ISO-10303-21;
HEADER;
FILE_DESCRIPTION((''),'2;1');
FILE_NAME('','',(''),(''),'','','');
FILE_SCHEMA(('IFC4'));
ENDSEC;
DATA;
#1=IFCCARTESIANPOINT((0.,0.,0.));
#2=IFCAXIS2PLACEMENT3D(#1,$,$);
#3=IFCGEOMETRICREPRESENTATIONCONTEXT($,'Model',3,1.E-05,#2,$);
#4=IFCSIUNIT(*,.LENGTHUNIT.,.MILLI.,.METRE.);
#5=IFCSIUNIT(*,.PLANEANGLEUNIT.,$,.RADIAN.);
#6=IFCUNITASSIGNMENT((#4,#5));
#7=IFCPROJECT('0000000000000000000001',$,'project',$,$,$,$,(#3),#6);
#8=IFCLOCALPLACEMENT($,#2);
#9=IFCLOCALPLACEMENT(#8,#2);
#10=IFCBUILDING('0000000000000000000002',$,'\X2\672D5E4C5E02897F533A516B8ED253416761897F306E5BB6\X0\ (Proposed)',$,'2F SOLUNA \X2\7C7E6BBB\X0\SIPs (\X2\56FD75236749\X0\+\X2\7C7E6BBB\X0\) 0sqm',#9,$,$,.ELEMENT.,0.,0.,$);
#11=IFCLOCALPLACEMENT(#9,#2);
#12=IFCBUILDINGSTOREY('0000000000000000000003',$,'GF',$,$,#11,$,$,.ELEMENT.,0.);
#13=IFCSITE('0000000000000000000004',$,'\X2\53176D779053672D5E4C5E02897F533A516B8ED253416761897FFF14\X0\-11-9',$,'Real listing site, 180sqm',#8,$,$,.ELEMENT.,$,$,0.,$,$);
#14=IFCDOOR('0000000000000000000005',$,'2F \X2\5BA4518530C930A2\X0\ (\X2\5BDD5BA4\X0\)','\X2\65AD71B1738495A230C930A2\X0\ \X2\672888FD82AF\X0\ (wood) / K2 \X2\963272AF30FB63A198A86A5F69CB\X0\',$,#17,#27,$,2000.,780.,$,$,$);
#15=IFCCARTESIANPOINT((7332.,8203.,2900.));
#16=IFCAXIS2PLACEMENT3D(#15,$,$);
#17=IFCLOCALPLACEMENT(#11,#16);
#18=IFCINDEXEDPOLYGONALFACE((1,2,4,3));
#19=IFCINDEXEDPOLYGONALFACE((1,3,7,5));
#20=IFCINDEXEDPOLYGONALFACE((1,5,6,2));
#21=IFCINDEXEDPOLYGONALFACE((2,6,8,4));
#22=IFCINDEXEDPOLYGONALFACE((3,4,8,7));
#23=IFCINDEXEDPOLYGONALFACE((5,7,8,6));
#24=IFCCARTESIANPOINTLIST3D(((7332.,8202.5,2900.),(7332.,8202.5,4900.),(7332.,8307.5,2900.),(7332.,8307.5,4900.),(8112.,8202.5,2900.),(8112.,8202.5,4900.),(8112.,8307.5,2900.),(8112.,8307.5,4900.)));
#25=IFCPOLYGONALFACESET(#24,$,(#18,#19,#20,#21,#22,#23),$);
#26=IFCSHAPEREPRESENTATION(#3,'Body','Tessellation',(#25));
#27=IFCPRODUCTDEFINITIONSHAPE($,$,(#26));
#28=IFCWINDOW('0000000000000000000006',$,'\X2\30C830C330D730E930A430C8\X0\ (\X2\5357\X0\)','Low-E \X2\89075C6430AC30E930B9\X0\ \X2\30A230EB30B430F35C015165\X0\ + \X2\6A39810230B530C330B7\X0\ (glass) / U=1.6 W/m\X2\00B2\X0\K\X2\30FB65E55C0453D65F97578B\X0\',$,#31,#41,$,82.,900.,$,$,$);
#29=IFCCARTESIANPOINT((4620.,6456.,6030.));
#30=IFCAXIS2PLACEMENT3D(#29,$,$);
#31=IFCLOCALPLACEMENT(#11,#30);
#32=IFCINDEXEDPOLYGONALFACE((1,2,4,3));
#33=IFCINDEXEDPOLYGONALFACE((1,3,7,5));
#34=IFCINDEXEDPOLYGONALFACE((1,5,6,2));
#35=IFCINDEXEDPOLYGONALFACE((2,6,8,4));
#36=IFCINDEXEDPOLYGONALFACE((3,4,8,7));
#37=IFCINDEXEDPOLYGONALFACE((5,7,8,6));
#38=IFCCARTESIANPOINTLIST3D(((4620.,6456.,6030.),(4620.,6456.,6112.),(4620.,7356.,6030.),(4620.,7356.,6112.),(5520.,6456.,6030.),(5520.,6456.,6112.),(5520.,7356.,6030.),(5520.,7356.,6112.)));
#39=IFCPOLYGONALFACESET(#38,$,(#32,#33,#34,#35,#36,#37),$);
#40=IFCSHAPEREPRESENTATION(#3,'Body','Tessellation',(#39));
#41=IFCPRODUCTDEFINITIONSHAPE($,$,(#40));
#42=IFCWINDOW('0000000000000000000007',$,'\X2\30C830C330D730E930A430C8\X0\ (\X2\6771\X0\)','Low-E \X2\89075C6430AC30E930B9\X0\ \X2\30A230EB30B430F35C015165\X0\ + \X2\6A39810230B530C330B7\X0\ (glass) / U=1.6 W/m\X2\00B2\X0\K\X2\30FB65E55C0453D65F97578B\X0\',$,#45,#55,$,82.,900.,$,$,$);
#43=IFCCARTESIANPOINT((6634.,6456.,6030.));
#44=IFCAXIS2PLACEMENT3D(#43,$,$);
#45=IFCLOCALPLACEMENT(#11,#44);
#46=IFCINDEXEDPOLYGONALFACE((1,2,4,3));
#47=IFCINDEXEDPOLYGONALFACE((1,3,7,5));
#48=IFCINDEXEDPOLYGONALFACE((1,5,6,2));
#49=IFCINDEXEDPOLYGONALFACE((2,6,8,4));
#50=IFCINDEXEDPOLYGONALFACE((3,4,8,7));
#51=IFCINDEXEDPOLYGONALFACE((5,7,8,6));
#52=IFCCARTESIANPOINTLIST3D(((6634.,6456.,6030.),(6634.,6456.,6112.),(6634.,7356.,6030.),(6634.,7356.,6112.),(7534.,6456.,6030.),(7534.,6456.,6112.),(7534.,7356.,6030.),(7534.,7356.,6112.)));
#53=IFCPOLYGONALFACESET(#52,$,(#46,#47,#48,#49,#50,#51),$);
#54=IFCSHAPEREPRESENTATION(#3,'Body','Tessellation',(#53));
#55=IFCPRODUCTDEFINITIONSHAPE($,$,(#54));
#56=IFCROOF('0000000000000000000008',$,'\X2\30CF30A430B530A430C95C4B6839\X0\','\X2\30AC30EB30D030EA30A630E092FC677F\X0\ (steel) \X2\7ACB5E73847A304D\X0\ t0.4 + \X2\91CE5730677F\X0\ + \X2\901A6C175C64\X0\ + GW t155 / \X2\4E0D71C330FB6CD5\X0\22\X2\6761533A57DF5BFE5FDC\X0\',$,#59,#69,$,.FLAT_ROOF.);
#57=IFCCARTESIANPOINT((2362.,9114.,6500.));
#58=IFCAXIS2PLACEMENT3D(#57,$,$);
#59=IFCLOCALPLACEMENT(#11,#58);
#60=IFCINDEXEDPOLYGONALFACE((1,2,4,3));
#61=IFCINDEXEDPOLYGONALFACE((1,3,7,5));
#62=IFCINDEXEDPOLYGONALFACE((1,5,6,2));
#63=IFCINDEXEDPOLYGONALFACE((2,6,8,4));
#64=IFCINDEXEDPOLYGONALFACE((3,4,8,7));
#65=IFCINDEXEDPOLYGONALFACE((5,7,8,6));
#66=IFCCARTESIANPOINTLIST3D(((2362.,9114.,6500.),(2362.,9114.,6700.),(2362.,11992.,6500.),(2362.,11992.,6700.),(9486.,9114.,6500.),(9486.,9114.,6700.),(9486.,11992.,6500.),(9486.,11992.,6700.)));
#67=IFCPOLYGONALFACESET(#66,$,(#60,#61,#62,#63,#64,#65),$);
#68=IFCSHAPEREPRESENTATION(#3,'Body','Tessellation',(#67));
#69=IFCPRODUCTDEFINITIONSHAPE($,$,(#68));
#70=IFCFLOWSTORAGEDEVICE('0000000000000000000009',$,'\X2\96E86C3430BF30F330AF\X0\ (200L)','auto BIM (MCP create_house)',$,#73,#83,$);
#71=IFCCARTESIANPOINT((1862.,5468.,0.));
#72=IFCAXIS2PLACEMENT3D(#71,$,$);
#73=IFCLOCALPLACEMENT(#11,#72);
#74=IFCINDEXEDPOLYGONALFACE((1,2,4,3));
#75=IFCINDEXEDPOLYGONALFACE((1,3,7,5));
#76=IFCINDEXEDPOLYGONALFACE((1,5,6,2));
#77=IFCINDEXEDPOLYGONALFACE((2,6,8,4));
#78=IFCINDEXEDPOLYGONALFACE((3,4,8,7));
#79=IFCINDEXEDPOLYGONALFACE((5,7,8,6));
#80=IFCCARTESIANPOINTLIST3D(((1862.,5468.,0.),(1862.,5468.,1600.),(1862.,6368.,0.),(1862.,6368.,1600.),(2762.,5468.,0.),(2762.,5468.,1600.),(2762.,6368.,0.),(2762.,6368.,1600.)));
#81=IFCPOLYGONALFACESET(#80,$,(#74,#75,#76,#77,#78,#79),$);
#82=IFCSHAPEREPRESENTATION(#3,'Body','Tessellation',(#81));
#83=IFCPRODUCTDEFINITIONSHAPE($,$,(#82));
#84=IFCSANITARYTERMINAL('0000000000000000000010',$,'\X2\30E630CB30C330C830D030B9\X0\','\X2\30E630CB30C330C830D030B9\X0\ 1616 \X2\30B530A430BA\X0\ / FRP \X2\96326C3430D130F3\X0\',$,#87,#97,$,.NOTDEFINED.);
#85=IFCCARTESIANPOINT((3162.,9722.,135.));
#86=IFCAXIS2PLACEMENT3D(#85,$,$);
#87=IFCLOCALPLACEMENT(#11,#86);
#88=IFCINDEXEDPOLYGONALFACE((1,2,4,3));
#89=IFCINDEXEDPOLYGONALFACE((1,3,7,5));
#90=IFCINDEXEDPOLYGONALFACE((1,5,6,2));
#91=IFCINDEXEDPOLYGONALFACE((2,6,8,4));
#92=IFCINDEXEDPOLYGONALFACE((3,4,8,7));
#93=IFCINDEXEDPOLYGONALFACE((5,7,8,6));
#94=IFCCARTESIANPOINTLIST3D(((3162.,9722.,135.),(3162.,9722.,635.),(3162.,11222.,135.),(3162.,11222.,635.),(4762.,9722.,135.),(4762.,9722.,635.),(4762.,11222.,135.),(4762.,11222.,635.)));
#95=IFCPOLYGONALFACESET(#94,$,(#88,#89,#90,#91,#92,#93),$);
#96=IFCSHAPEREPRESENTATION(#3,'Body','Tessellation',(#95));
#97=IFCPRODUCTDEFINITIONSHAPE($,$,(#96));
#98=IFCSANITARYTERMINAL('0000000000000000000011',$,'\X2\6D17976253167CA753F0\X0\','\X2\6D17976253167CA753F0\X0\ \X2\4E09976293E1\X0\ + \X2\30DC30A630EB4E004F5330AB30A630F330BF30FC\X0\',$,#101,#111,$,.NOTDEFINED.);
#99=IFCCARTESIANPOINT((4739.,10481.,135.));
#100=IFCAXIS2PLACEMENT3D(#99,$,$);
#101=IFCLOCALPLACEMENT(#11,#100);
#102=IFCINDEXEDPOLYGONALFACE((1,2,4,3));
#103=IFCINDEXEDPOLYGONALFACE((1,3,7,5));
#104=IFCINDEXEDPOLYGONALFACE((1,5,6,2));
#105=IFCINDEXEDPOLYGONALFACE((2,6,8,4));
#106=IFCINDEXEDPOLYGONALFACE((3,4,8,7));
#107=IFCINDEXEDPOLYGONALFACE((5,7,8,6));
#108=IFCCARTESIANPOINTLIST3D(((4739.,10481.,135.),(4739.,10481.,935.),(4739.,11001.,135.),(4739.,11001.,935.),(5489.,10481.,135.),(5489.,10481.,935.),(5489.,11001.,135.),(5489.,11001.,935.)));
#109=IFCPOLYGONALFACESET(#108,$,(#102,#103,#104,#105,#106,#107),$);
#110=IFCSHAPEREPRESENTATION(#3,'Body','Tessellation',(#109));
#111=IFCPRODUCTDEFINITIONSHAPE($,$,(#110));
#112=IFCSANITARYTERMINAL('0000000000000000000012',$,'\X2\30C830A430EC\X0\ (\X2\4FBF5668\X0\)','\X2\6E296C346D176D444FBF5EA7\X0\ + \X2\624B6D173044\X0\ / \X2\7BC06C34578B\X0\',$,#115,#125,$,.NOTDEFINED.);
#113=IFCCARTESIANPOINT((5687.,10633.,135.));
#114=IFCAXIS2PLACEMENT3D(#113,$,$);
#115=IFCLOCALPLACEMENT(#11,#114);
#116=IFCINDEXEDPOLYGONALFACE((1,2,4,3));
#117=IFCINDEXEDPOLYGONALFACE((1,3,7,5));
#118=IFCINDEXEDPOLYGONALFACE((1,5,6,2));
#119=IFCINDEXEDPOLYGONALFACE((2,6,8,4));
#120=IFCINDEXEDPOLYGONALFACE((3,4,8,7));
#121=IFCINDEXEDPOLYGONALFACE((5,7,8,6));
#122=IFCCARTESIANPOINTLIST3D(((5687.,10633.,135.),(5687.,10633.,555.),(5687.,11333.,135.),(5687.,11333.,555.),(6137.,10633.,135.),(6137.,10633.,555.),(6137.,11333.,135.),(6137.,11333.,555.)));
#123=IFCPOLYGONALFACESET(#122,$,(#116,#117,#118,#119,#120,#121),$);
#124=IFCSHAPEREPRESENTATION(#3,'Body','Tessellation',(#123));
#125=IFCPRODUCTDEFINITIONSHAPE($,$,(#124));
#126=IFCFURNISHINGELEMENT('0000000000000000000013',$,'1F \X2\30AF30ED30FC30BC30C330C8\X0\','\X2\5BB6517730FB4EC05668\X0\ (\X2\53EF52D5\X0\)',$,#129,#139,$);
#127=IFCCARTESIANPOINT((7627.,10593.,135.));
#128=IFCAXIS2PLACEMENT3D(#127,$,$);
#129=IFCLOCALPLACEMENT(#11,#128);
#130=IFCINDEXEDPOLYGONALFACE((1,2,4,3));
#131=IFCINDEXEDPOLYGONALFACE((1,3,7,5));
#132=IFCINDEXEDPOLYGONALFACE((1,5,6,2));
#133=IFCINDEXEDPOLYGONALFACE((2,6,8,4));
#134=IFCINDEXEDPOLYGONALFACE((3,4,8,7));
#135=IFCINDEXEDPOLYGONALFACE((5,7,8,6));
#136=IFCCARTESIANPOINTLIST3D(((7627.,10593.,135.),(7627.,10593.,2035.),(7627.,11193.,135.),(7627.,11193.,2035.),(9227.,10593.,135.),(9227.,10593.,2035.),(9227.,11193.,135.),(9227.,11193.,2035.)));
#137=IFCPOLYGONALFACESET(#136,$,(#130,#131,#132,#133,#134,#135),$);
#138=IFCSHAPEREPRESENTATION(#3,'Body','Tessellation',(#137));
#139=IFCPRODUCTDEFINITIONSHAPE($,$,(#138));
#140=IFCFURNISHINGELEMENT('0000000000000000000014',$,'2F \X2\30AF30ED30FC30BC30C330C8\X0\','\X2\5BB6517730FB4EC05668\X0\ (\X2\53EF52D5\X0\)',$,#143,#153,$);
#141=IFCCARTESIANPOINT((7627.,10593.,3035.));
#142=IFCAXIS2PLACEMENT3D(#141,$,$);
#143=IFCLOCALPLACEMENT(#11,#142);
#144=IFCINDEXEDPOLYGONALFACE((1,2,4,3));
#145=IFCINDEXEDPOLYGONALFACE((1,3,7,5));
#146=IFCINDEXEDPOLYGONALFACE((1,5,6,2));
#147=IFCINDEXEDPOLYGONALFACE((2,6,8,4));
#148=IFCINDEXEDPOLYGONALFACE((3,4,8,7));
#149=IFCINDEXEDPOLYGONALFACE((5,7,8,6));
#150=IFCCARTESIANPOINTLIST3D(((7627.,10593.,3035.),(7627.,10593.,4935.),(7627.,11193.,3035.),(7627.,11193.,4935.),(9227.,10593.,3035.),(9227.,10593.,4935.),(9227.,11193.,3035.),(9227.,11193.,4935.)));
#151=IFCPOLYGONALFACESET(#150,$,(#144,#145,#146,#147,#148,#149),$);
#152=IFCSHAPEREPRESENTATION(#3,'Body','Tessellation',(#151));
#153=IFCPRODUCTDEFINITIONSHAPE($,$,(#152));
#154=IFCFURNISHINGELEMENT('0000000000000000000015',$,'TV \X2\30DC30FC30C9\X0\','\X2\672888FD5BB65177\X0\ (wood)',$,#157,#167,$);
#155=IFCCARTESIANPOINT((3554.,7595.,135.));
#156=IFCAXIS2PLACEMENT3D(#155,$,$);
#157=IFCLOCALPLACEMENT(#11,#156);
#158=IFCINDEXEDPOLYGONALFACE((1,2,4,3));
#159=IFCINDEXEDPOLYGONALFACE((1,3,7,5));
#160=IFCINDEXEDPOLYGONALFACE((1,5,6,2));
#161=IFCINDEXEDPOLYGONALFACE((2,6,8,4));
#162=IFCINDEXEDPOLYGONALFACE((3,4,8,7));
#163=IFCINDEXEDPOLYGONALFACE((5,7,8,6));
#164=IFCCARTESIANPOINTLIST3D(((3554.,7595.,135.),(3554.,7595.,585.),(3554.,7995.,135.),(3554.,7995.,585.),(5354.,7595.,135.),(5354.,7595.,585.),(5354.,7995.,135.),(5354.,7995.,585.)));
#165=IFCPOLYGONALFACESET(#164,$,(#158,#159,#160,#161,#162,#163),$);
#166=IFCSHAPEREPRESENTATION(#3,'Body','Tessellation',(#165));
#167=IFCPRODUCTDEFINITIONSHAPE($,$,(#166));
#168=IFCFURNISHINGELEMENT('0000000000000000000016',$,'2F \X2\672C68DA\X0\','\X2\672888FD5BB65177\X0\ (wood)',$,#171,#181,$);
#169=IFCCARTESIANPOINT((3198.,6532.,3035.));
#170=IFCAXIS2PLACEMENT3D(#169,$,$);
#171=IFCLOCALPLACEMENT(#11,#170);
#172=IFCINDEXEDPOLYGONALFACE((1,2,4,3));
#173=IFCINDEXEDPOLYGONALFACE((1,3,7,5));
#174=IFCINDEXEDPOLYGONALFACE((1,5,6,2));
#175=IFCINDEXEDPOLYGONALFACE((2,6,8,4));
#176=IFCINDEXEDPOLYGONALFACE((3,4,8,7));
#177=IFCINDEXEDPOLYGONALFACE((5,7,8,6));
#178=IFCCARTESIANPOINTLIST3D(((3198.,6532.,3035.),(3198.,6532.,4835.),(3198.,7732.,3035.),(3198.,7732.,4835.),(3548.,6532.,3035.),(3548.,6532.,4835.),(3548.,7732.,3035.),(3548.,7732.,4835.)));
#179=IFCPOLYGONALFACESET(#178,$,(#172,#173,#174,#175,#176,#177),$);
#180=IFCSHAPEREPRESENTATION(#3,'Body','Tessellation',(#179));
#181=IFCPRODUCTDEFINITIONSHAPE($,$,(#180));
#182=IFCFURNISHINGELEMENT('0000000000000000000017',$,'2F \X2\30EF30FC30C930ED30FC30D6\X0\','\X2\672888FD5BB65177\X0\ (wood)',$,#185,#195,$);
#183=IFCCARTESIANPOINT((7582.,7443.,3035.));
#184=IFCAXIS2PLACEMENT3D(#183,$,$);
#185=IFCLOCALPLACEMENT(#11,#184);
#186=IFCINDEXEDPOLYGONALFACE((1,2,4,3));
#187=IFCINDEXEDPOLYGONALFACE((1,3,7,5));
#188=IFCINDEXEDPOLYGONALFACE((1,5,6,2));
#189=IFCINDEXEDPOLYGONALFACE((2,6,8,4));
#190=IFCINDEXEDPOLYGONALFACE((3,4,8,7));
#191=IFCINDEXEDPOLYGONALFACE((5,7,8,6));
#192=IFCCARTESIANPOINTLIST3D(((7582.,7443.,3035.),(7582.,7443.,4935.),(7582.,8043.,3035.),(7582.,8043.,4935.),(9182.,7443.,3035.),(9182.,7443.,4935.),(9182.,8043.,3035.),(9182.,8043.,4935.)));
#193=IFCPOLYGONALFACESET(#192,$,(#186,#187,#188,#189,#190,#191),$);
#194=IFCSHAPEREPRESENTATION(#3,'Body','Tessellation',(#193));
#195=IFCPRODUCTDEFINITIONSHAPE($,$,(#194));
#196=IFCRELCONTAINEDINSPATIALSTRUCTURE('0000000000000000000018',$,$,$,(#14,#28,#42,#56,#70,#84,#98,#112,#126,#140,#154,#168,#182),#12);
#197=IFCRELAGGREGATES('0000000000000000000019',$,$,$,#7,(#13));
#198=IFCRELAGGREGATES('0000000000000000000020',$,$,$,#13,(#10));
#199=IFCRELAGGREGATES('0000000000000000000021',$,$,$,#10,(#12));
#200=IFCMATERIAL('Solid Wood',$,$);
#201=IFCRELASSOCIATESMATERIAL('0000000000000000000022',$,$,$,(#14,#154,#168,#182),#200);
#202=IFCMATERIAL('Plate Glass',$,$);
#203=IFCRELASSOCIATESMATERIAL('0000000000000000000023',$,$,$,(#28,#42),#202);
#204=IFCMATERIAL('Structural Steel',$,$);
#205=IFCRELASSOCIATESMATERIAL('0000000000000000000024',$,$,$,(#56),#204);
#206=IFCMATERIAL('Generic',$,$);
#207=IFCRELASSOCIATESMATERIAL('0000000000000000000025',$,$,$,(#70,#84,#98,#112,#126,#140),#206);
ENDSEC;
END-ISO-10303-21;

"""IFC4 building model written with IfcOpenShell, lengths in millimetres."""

from ifc_helpers import new_model, si_unit, frame, frame_2d, origin, place, context, project, spatial, rectangle, extrude, material, element, save


model = new_model("IFC4")

# Units and contexts
model_context = context("Model", 3, precision=1e-05, world=origin())
ifc_project = project(units=[si_unit("LENGTHUNIT", "METRE", prefix="MILLI"), si_unit("PLANEANGLEUNIT", "RADIAN")], contexts=[model_context])

# Site, building, storey
site_placement = place(None, origin())
site = spatial("IfcSite", under=ifc_project, at=site_placement, Name="北海道札幌市西区八軒十条西４-11-9", ObjectType="Real listing site, 180sqm", CompositionType="ELEMENT", RefElevation=0.0)
building_placement = place(site_placement, origin())
building = spatial("IfcBuilding", under=site, at=building_placement, Name="札幌市西区八軒十条西の家 (Proposed)", ObjectType="2F SOLUNA 籾殻SIPs (国産杉+籾殻) 0sqm", CompositionType="ELEMENT", ElevationOfRefHeight=0.0, ElevationOfTerrain=0.0)
storey_placement = place(building_placement, origin())
storey = spatial("IfcBuildingStorey", under=building, at=storey_placement, Name="GF", CompositionType="ELEMENT", Elevation=0.0)

# Shared definitions
ifc_material_1 = material(Name="Solid Wood")
ifc_material_2 = material(Name="Plate Glass")

# Door
door_1_placement = place(storey_placement, frame((7332.0, 8203.0, 2900.0)))
element("IfcDoor", 1, at=door_1_placement, inside=storey, material=ifc_material_1, Name="2F 室内ドア (寝室)", Description="断熱玄関ドア 木製芯 (wood) / K2 防犯・採風機構", OverallHeight=2000.0, OverallWidth=780.0, context=model_context, shape_type="SweptSolid", body=[
    extrude(rectangle(XDim=780.0, YDim=105.0, at=frame_2d((390.0, 52.0))), frame((7332.0, 8203.0, 2900.0)), (0.0, 0.0, 1.0), 2000.0),
])

# Windows
window_1_placement = place(storey_placement, frame((4620.0, 6456.0, 6030.0)))
element("IfcWindow", 2, at=window_1_placement, inside=storey, material=ifc_material_2, Name="トップライト (南)", Description="Low-E 複層ガラス アルゴン封入 + 樹脂サッシ (glass) / U=1.6 W/m²K・日射取得型", OverallHeight=82.0, OverallWidth=900.0, context=model_context, shape_type="SweptSolid", body=[
    extrude(rectangle(XDim=900.0, YDim=900.0, at=frame_2d((450.0, 450.0))), frame((4620.0, 6456.0, 6030.0)), (0.0, 0.0, 1.0), 82.0),
])
window_2_placement = place(storey_placement, frame((6634.0, 6456.0, 6030.0)))
element("IfcWindow", 3, at=window_2_placement, inside=storey, material=ifc_material_2, Name="トップライト (東)", Description="Low-E 複層ガラス アルゴン封入 + 樹脂サッシ (glass) / U=1.6 W/m²K・日射取得型", OverallHeight=82.0, OverallWidth=900.0, context=model_context, shape_type="SweptSolid", body=[
    extrude(rectangle(XDim=900.0, YDim=900.0, at=frame_2d((450.0, 450.0))), frame((6634.0, 6456.0, 6030.0)), (0.0, 0.0, 1.0), 82.0),
])

# Roof
ifc_material_3 = material(Name="Structural Steel")
roof_placement = place(storey_placement, frame((2362.0, 9114.0, 6500.0)))
element("IfcRoof", 4, at=roof_placement, inside=storey, material=ifc_material_3, Name="ハイサイド屋根", Description="ガルバリウム鋼板 (steel) 立平葺き t0.4 + 野地板 + 通気層 + GW t155 / 不燃・法22条区域対応", PredefinedType="FLAT_ROOF", context=model_context, shape_type="SweptSolid", body=[
    extrude(rectangle(XDim=7124.0, YDim=2878.0, at=frame_2d((3562.0, 1439.0))), frame((2362.0, 9114.0, 6500.0)), (0.0, 0.0, 1.0), 200.0),
])

# Flow storage device
ifc_material_4 = material(Name="Generic")
flow_storage_device_placement = place(storey_placement, frame((1862.0, 5468.0, 0.0)))
element("IfcFlowStorageDevice", 5, at=flow_storage_device_placement, inside=storey, material=ifc_material_4, Name="雨水タンク (200L)", Description="auto BIM (MCP create_house)", context=model_context, shape_type="SweptSolid", body=[
    extrude(rectangle(XDim=900.0, YDim=900.0, at=frame_2d((450.0, 450.0))), frame((1862.0, 5468.0, 0.0)), (0.0, 0.0, 1.0), 1600.0),
])

# Sanitary terminals
sanitary_terminal_1_placement = place(storey_placement, frame((3162.0, 9722.0, 135.0)))
element("IfcSanitaryTerminal", 6, at=sanitary_terminal_1_placement, inside=storey, material=ifc_material_4, Name="ユニットバス", Description="ユニットバス 1616 サイズ / FRP 防水パン", PredefinedType="NOTDEFINED", context=model_context, shape_type="SweptSolid", body=[
    extrude(rectangle(XDim=1600.0, YDim=1500.0, at=frame_2d((800.0, 750.0))), frame((3162.0, 9722.0, 135.0)), (0.0, 0.0, 1.0), 500.0),
])
sanitary_terminal_2_placement = place(storey_placement, frame((4739.0, 10481.0, 135.0)))
element("IfcSanitaryTerminal", 7, at=sanitary_terminal_2_placement, inside=storey, material=ifc_material_4, Name="洗面化粧台", Description="洗面化粧台 三面鏡 + ボウル一体カウンター", PredefinedType="NOTDEFINED", context=model_context, shape_type="SweptSolid", body=[
    extrude(rectangle(XDim=750.0, YDim=520.0, at=frame_2d((375.0, 260.0))), frame((4739.0, 10481.0, 135.0)), (0.0, 0.0, 1.0), 800.0),
])
sanitary_terminal_3_placement = place(storey_placement, frame((5687.0, 10633.0, 135.0)))
element("IfcSanitaryTerminal", 8, at=sanitary_terminal_3_placement, inside=storey, material=ifc_material_4, Name="トイレ (便器)", Description="温水洗浄便座 + 手洗い / 節水型", PredefinedType="NOTDEFINED", context=model_context, shape_type="SweptSolid", body=[
    extrude(rectangle(XDim=450.0, YDim=700.0, at=frame_2d((225.0, 350.0))), frame((5687.0, 10633.0, 135.0)), (0.0, 0.0, 1.0), 420.0),
])

# Furnishing elements
furnishing_1_placement = place(storey_placement, frame((7627.0, 10593.0, 135.0)))
element("IfcFurnishingElement", 9, at=furnishing_1_placement, inside=storey, material=ifc_material_4, Name="1F クローゼット", Description="家具・什器 (可動)", context=model_context, shape_type="SweptSolid", body=[
    extrude(rectangle(XDim=1600.0, YDim=600.0, at=frame_2d((800.0, 300.0))), frame((7627.0, 10593.0, 135.0)), (0.0, 0.0, 1.0), 1900.0),
])
furnishing_2_placement = place(storey_placement, frame((7627.0, 10593.0, 3035.0)))
element("IfcFurnishingElement", 10, at=furnishing_2_placement, inside=storey, material=ifc_material_4, Name="2F クローゼット", Description="家具・什器 (可動)", context=model_context, shape_type="SweptSolid", body=[
    extrude(rectangle(XDim=1600.0, YDim=600.0, at=frame_2d((800.0, 300.0))), frame((7627.0, 10593.0, 3035.0)), (0.0, 0.0, 1.0), 1900.0),
])
furnishing_3_placement = place(storey_placement, frame((3554.0, 7595.0, 135.0)))
element("IfcFurnishingElement", 11, at=furnishing_3_placement, inside=storey, material=ifc_material_1, Name="TV ボード", Description="木製家具 (wood)", context=model_context, shape_type="SweptSolid", body=[
    extrude(rectangle(XDim=1800.0, YDim=400.0, at=frame_2d((900.0, 200.0))), frame((3554.0, 7595.0, 135.0)), (0.0, 0.0, 1.0), 450.0),
])
furnishing_4_placement = place(storey_placement, frame((3198.0, 6532.0, 3035.0)))
element("IfcFurnishingElement", 12, at=furnishing_4_placement, inside=storey, material=ifc_material_1, Name="2F 本棚", Description="木製家具 (wood)", context=model_context, shape_type="SweptSolid", body=[
    extrude(rectangle(XDim=350.0, YDim=1200.0, at=frame_2d((175.0, 600.0))), frame((3198.0, 6532.0, 3035.0)), (0.0, 0.0, 1.0), 1800.0),
])
furnishing_5_placement = place(storey_placement, frame((7582.0, 7443.0, 3035.0)))
element("IfcFurnishingElement", 13, at=furnishing_5_placement, inside=storey, material=ifc_material_1, Name="2F ワードローブ", Description="木製家具 (wood)", context=model_context, shape_type="SweptSolid", body=[
    extrude(rectangle(XDim=1600.0, YDim=600.0, at=frame_2d((800.0, 300.0))), frame((7582.0, 7443.0, 3035.0)), (0.0, 0.0, 1.0), 1900.0),
])

save(model, "model.ifc")
